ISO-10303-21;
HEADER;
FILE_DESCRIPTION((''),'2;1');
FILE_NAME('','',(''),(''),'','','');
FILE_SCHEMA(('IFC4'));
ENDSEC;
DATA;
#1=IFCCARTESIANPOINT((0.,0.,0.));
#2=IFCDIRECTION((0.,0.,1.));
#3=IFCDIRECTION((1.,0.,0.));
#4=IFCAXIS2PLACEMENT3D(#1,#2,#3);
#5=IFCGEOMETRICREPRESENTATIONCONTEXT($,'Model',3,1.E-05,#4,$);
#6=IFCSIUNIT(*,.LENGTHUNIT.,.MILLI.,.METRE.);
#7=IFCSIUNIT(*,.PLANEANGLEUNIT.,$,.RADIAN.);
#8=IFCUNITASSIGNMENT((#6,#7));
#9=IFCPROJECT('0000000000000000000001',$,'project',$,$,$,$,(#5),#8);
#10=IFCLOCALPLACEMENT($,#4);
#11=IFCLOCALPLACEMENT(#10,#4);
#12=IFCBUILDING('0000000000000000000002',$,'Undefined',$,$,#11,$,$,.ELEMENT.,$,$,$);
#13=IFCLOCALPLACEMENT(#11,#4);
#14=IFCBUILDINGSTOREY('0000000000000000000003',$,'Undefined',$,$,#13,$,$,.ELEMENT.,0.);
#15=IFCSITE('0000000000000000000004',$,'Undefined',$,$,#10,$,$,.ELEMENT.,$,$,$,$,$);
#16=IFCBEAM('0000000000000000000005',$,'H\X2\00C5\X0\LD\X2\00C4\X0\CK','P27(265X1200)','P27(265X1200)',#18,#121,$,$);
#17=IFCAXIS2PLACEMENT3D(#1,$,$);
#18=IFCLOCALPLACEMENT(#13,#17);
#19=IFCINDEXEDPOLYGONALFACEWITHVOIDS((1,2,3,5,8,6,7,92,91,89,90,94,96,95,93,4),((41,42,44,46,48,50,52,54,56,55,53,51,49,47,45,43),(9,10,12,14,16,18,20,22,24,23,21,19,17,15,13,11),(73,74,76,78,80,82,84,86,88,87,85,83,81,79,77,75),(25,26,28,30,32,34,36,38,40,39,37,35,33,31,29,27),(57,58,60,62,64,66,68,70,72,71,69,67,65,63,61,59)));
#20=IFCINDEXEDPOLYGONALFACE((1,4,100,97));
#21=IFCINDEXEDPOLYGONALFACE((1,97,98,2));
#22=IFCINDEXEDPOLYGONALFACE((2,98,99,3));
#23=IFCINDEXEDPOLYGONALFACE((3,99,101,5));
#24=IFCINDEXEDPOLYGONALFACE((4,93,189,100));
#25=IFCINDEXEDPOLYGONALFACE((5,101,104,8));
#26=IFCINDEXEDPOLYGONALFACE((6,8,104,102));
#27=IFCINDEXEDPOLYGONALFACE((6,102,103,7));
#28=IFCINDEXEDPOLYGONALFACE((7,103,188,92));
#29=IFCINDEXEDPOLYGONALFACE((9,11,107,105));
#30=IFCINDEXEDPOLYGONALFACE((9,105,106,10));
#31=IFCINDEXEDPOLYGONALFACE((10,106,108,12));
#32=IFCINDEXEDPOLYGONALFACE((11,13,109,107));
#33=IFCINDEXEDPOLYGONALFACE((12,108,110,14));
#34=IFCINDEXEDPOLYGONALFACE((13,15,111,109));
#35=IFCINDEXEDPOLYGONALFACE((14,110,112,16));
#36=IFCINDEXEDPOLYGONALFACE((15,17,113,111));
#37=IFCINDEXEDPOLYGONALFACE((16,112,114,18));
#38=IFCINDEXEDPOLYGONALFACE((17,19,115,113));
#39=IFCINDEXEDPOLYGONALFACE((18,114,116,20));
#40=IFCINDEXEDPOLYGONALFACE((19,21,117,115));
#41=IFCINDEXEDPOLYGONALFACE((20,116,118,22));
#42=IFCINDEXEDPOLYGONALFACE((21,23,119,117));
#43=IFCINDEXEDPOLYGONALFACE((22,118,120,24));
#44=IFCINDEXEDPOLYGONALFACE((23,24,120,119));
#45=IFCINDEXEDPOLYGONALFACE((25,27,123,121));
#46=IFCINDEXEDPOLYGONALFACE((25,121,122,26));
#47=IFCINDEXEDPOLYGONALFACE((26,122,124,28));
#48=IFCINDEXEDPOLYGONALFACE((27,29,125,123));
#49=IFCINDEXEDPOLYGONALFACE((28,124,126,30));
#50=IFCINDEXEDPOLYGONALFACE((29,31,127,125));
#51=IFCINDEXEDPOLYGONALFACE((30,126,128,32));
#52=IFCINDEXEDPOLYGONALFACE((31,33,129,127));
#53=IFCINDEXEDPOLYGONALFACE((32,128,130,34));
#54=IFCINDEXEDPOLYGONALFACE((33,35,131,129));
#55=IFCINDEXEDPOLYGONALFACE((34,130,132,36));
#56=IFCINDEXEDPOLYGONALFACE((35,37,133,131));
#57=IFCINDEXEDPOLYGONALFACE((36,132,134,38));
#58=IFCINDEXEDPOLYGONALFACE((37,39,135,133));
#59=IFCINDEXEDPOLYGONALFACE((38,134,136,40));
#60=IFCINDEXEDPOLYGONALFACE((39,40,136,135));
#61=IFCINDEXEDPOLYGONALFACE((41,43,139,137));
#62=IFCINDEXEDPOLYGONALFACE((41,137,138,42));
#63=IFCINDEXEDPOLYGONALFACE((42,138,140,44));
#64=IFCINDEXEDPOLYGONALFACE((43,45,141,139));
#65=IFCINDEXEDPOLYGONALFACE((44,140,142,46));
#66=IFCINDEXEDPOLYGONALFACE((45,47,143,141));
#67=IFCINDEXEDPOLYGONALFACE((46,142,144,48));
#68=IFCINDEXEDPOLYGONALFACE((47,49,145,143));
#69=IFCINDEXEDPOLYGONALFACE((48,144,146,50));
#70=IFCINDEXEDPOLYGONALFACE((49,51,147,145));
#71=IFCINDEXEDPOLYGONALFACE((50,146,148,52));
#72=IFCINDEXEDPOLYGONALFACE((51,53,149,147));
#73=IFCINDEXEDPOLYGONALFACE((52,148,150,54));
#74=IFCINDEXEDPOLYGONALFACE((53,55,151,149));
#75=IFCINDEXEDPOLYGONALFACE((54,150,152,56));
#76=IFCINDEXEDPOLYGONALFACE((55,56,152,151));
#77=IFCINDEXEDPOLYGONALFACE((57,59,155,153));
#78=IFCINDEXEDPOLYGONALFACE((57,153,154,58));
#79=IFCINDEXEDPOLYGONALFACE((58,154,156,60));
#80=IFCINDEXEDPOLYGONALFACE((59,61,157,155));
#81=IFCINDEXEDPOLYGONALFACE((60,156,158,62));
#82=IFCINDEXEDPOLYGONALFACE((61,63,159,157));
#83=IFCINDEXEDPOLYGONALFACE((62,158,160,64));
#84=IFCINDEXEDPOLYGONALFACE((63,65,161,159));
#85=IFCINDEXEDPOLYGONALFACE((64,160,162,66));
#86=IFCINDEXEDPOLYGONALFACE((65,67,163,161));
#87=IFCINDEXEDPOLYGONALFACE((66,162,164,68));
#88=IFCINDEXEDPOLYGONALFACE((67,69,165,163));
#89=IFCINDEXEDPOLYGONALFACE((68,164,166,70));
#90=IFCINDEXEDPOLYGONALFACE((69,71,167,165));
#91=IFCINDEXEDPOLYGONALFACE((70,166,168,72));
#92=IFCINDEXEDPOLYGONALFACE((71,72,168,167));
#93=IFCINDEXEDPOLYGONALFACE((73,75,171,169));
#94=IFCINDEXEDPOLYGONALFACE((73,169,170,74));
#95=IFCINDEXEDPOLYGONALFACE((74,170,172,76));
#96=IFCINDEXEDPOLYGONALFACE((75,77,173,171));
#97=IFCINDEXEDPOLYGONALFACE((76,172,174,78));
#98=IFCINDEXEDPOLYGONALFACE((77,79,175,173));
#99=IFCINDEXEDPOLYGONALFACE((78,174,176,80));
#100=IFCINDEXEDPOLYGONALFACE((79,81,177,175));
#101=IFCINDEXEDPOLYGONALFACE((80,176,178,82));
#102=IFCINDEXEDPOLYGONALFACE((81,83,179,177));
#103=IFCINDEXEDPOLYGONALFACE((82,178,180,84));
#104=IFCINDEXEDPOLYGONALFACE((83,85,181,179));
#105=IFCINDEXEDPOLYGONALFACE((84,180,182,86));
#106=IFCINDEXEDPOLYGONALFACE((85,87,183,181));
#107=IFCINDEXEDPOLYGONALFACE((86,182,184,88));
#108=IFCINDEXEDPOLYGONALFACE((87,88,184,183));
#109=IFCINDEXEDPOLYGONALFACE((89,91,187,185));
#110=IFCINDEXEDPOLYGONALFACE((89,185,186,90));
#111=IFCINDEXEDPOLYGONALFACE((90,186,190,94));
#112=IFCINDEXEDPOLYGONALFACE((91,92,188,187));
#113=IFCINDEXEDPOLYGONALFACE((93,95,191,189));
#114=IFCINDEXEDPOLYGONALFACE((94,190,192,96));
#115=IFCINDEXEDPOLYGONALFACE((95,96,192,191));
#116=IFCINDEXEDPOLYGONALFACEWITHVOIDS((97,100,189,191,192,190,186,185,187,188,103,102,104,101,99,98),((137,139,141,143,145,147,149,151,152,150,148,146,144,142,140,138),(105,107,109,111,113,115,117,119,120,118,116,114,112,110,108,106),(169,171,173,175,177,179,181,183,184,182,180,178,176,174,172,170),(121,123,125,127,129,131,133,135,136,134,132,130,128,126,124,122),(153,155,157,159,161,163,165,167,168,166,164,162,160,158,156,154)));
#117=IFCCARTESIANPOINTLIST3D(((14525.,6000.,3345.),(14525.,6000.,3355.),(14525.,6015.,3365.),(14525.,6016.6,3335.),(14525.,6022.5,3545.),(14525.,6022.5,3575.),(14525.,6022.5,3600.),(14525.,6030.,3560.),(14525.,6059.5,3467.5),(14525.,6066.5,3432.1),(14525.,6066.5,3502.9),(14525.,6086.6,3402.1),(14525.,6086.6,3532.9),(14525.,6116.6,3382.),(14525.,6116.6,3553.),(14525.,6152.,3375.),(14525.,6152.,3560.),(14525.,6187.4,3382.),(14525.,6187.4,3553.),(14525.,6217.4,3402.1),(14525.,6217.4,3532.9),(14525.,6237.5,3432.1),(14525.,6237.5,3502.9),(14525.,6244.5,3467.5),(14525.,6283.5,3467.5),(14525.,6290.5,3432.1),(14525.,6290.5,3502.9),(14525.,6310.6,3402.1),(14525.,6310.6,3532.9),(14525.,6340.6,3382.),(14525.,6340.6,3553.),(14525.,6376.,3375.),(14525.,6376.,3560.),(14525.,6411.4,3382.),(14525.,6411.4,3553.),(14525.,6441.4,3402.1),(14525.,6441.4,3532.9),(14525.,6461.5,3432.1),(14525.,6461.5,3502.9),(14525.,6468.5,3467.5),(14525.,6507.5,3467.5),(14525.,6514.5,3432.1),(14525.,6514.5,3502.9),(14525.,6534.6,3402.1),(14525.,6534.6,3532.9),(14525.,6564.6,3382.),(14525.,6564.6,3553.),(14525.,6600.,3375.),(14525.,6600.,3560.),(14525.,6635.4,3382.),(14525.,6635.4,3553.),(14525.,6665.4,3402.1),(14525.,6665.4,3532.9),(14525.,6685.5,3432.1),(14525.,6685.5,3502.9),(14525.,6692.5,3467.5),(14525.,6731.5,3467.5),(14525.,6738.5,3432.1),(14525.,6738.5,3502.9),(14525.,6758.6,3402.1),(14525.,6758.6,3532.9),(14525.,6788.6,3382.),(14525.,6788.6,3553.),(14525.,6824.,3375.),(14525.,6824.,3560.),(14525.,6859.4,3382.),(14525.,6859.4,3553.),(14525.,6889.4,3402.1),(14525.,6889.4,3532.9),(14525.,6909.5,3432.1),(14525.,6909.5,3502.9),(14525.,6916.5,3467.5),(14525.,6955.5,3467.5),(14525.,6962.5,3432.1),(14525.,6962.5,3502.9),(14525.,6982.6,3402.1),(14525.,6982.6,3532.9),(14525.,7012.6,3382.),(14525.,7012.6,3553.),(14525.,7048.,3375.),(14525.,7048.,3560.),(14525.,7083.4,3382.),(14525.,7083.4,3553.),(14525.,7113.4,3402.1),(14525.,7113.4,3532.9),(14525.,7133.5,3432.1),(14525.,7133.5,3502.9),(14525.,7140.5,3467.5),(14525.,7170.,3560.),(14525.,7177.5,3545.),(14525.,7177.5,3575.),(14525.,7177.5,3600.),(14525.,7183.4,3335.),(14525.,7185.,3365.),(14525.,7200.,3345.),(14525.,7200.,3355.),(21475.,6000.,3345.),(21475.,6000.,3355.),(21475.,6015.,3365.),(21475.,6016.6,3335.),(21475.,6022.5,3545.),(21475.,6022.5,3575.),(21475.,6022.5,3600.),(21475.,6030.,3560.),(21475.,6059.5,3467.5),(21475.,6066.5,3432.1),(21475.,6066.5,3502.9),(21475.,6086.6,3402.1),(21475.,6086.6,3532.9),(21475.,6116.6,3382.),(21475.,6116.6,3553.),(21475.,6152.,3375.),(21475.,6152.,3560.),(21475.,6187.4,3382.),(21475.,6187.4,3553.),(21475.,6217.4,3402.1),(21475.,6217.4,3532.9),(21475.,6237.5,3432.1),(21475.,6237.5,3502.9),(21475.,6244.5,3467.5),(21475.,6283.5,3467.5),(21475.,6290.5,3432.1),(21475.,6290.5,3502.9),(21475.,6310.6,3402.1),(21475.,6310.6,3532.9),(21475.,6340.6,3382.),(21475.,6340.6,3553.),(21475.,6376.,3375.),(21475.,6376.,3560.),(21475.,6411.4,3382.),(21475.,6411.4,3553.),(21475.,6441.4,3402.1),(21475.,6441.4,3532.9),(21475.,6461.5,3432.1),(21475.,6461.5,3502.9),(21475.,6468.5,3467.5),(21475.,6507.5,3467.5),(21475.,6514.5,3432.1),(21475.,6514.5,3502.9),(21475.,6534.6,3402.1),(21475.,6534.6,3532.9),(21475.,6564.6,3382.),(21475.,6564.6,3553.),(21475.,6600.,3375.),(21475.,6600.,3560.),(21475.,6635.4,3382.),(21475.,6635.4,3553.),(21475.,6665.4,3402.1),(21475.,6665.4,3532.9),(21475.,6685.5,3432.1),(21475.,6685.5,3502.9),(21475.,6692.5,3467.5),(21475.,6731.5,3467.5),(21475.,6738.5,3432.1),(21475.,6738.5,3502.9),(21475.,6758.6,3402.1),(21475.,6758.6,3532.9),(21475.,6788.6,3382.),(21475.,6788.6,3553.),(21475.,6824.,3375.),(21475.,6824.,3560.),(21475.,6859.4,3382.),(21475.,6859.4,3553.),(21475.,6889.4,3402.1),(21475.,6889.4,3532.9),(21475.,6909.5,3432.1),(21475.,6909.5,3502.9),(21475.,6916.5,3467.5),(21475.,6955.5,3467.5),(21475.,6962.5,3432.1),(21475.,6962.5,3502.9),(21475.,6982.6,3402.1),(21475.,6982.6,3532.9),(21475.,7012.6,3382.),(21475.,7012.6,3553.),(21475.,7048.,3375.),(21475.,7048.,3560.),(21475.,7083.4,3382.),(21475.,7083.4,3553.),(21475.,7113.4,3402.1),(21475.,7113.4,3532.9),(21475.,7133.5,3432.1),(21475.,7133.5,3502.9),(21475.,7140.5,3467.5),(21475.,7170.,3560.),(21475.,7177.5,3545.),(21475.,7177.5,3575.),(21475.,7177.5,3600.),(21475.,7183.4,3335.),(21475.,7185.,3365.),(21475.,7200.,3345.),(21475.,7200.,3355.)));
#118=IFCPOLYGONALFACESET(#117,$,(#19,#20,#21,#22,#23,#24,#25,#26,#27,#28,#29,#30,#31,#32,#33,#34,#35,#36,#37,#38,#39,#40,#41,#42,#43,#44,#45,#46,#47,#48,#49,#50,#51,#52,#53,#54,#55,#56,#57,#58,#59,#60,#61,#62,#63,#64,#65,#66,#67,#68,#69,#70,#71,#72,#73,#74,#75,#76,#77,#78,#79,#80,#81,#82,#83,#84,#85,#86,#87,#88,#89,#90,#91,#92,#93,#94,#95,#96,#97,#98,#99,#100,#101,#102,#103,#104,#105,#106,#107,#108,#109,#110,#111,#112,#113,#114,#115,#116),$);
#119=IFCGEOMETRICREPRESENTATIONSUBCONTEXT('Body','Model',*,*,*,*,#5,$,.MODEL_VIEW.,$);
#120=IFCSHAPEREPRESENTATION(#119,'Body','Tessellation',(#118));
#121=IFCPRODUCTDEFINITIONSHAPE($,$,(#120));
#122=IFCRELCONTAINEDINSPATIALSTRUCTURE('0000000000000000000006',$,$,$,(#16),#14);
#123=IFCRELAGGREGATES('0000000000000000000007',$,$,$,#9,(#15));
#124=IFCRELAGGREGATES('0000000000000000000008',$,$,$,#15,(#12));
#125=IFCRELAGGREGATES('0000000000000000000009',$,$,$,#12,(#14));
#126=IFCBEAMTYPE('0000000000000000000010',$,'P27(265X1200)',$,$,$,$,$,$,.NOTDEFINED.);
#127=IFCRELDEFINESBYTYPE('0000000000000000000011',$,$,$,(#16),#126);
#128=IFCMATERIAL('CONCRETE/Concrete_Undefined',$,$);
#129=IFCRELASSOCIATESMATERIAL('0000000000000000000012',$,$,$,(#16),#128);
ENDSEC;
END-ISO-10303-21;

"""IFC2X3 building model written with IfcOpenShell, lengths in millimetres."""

from ifc_helpers import new_model, si_unit, frame, origin_with_axes, place, context, subcontext, project, spatial, polyline, outline, extrude, material, type_object, element, save


model = new_model("IFC2X3")

# Units and contexts
model_context = context("Model", 3, precision=1e-05, world=origin_with_axes())
body_context = subcontext(model_context, "Body", "Model", "MODEL_VIEW")
ifc_project = project(units=[si_unit("LENGTHUNIT", "METRE", prefix="MILLI"), si_unit("PLANEANGLEUNIT", "RADIAN")], contexts=[model_context])

# Site, building, storey
site_placement = place(None, origin_with_axes())
site = spatial("IfcSite", under=ifc_project, at=site_placement, Name="Undefined", CompositionType="ELEMENT")
building_placement = place(site_placement, origin_with_axes())
building = spatial("IfcBuilding", under=site, at=building_placement, Name="Undefined", CompositionType="ELEMENT")
storey_placement = place(building_placement, origin_with_axes())
storey = spatial("IfcBuildingStorey", under=building, at=storey_placement, Name="Undefined", CompositionType="ELEMENT", Elevation=0.0)

# Beam
ifc_material_1 = material(Name="CONCRETE/Concrete_Undefined")
beam_type_1 = type_object("IfcBeamType", Name="P27(265X1200)", PredefinedType="NOTDEFINED")
beam_1_placement = place(storey_placement, frame((14525.0, 6600.0, 3467.5), z_axis=(0.0, 0.0, 1.0), x_axis=(1.0, 0.0, 0.0)))
element("IfcBeam", 1, at=beam_1_placement, inside=storey, type_object=beam_type_1, material=ifc_material_1, Name="HÅLDÄCK", Description="P27(265X1200)", ObjectType="P27(265X1200)", context=body_context, shape_type="SweptSolid", body=[
    extrude(outline(polyline([(-583.4, -132.5), (-600.0, -122.5), (-600.0, -112.5), (-585.0, -102.5), (-577.5, 77.5), (-570.0, 92.5), (-577.5, 107.5), (-577.5, 132.5), (577.5, 132.5), (577.5, 107.5), (570.0, 92.5), (577.5, 77.5), (585.0, -102.5), (600.0, -112.5), (600.0, -122.5), (583.4, -132.5), (-583.4, -132.5)]), holes=[polyline([(-513.4, 65.4), (-533.5, 35.4), (-540.5, 0.0), (-533.5, -35.4), (-513.4, -65.4), (-483.4, -85.5), (-448.0, -92.5), (-412.6, -85.5), (-382.6, -65.4), (-362.5, -35.4), (-355.5, 0.0), (-362.5, 35.4), (-382.6, 65.4), (-412.6, 85.5), (-448.0, 92.5), (-483.4, 85.5), (-513.4, 65.4)]), polyline([(-289.4, 65.4), (-309.5, 35.4), (-316.5, 0.0), (-309.5, -35.4), (-289.4, -65.4), (-259.4, -85.5), (-224.0, -92.5), (-188.6, -85.5), (-158.6, -65.4), (-138.5, -35.4), (-131.5, 0.0), (-138.5, 35.4), (-158.6, 65.4), (-188.6, 85.5), (-224.0, 92.5), (-259.4, 85.5), (-289.4, 65.4)]), polyline([(-65.4, 65.4), (-85.5, 35.4), (-92.5, 0.0), (-85.5, -35.4), (-65.4, -65.4), (-35.4, -85.5), (0.0, -92.5), (35.4, -85.5), (65.4, -65.4), (85.5, -35.4), (92.5, 0.0), (85.5, 35.4), (65.4, 65.4), (35.4, 85.5), (0.0, 92.5), (-35.4, 85.5), (-65.4, 65.4)]), polyline([(158.6, 65.4), (138.5, 35.4), (131.5, 0.0), (138.5, -35.4), (158.6, -65.4), (188.6, -85.5), (224.0, -92.5), (259.4, -85.5), (289.4, -65.4), (309.5, -35.4), (316.5, 0.0), (309.5, 35.4), (289.4, 65.4), (259.4, 85.5), (224.0, 92.5), (188.6, 85.5), (158.6, 65.4)]), polyline([(382.6, 65.4), (362.5, 35.4), (355.5, 0.0), (362.5, -35.4), (382.6, -65.4), (412.6, -85.5), (448.0, -92.5), (483.4, -85.5), (513.4, -65.4), (533.5, -35.4), (540.5, 0.0), (533.5, 35.4), (513.4, 65.4), (483.4, 85.5), (448.0, 92.5), (412.6, 85.5), (382.6, 65.4)])]), frame((6950.0, 0.0, 0.0), z_axis=(-1.0, 0.0, 0.0), x_axis=(0.0, -1.0, 0.0)), (0.0, 0.0, 1.0), 6950.0),
])

save(model, "model.ifc")
